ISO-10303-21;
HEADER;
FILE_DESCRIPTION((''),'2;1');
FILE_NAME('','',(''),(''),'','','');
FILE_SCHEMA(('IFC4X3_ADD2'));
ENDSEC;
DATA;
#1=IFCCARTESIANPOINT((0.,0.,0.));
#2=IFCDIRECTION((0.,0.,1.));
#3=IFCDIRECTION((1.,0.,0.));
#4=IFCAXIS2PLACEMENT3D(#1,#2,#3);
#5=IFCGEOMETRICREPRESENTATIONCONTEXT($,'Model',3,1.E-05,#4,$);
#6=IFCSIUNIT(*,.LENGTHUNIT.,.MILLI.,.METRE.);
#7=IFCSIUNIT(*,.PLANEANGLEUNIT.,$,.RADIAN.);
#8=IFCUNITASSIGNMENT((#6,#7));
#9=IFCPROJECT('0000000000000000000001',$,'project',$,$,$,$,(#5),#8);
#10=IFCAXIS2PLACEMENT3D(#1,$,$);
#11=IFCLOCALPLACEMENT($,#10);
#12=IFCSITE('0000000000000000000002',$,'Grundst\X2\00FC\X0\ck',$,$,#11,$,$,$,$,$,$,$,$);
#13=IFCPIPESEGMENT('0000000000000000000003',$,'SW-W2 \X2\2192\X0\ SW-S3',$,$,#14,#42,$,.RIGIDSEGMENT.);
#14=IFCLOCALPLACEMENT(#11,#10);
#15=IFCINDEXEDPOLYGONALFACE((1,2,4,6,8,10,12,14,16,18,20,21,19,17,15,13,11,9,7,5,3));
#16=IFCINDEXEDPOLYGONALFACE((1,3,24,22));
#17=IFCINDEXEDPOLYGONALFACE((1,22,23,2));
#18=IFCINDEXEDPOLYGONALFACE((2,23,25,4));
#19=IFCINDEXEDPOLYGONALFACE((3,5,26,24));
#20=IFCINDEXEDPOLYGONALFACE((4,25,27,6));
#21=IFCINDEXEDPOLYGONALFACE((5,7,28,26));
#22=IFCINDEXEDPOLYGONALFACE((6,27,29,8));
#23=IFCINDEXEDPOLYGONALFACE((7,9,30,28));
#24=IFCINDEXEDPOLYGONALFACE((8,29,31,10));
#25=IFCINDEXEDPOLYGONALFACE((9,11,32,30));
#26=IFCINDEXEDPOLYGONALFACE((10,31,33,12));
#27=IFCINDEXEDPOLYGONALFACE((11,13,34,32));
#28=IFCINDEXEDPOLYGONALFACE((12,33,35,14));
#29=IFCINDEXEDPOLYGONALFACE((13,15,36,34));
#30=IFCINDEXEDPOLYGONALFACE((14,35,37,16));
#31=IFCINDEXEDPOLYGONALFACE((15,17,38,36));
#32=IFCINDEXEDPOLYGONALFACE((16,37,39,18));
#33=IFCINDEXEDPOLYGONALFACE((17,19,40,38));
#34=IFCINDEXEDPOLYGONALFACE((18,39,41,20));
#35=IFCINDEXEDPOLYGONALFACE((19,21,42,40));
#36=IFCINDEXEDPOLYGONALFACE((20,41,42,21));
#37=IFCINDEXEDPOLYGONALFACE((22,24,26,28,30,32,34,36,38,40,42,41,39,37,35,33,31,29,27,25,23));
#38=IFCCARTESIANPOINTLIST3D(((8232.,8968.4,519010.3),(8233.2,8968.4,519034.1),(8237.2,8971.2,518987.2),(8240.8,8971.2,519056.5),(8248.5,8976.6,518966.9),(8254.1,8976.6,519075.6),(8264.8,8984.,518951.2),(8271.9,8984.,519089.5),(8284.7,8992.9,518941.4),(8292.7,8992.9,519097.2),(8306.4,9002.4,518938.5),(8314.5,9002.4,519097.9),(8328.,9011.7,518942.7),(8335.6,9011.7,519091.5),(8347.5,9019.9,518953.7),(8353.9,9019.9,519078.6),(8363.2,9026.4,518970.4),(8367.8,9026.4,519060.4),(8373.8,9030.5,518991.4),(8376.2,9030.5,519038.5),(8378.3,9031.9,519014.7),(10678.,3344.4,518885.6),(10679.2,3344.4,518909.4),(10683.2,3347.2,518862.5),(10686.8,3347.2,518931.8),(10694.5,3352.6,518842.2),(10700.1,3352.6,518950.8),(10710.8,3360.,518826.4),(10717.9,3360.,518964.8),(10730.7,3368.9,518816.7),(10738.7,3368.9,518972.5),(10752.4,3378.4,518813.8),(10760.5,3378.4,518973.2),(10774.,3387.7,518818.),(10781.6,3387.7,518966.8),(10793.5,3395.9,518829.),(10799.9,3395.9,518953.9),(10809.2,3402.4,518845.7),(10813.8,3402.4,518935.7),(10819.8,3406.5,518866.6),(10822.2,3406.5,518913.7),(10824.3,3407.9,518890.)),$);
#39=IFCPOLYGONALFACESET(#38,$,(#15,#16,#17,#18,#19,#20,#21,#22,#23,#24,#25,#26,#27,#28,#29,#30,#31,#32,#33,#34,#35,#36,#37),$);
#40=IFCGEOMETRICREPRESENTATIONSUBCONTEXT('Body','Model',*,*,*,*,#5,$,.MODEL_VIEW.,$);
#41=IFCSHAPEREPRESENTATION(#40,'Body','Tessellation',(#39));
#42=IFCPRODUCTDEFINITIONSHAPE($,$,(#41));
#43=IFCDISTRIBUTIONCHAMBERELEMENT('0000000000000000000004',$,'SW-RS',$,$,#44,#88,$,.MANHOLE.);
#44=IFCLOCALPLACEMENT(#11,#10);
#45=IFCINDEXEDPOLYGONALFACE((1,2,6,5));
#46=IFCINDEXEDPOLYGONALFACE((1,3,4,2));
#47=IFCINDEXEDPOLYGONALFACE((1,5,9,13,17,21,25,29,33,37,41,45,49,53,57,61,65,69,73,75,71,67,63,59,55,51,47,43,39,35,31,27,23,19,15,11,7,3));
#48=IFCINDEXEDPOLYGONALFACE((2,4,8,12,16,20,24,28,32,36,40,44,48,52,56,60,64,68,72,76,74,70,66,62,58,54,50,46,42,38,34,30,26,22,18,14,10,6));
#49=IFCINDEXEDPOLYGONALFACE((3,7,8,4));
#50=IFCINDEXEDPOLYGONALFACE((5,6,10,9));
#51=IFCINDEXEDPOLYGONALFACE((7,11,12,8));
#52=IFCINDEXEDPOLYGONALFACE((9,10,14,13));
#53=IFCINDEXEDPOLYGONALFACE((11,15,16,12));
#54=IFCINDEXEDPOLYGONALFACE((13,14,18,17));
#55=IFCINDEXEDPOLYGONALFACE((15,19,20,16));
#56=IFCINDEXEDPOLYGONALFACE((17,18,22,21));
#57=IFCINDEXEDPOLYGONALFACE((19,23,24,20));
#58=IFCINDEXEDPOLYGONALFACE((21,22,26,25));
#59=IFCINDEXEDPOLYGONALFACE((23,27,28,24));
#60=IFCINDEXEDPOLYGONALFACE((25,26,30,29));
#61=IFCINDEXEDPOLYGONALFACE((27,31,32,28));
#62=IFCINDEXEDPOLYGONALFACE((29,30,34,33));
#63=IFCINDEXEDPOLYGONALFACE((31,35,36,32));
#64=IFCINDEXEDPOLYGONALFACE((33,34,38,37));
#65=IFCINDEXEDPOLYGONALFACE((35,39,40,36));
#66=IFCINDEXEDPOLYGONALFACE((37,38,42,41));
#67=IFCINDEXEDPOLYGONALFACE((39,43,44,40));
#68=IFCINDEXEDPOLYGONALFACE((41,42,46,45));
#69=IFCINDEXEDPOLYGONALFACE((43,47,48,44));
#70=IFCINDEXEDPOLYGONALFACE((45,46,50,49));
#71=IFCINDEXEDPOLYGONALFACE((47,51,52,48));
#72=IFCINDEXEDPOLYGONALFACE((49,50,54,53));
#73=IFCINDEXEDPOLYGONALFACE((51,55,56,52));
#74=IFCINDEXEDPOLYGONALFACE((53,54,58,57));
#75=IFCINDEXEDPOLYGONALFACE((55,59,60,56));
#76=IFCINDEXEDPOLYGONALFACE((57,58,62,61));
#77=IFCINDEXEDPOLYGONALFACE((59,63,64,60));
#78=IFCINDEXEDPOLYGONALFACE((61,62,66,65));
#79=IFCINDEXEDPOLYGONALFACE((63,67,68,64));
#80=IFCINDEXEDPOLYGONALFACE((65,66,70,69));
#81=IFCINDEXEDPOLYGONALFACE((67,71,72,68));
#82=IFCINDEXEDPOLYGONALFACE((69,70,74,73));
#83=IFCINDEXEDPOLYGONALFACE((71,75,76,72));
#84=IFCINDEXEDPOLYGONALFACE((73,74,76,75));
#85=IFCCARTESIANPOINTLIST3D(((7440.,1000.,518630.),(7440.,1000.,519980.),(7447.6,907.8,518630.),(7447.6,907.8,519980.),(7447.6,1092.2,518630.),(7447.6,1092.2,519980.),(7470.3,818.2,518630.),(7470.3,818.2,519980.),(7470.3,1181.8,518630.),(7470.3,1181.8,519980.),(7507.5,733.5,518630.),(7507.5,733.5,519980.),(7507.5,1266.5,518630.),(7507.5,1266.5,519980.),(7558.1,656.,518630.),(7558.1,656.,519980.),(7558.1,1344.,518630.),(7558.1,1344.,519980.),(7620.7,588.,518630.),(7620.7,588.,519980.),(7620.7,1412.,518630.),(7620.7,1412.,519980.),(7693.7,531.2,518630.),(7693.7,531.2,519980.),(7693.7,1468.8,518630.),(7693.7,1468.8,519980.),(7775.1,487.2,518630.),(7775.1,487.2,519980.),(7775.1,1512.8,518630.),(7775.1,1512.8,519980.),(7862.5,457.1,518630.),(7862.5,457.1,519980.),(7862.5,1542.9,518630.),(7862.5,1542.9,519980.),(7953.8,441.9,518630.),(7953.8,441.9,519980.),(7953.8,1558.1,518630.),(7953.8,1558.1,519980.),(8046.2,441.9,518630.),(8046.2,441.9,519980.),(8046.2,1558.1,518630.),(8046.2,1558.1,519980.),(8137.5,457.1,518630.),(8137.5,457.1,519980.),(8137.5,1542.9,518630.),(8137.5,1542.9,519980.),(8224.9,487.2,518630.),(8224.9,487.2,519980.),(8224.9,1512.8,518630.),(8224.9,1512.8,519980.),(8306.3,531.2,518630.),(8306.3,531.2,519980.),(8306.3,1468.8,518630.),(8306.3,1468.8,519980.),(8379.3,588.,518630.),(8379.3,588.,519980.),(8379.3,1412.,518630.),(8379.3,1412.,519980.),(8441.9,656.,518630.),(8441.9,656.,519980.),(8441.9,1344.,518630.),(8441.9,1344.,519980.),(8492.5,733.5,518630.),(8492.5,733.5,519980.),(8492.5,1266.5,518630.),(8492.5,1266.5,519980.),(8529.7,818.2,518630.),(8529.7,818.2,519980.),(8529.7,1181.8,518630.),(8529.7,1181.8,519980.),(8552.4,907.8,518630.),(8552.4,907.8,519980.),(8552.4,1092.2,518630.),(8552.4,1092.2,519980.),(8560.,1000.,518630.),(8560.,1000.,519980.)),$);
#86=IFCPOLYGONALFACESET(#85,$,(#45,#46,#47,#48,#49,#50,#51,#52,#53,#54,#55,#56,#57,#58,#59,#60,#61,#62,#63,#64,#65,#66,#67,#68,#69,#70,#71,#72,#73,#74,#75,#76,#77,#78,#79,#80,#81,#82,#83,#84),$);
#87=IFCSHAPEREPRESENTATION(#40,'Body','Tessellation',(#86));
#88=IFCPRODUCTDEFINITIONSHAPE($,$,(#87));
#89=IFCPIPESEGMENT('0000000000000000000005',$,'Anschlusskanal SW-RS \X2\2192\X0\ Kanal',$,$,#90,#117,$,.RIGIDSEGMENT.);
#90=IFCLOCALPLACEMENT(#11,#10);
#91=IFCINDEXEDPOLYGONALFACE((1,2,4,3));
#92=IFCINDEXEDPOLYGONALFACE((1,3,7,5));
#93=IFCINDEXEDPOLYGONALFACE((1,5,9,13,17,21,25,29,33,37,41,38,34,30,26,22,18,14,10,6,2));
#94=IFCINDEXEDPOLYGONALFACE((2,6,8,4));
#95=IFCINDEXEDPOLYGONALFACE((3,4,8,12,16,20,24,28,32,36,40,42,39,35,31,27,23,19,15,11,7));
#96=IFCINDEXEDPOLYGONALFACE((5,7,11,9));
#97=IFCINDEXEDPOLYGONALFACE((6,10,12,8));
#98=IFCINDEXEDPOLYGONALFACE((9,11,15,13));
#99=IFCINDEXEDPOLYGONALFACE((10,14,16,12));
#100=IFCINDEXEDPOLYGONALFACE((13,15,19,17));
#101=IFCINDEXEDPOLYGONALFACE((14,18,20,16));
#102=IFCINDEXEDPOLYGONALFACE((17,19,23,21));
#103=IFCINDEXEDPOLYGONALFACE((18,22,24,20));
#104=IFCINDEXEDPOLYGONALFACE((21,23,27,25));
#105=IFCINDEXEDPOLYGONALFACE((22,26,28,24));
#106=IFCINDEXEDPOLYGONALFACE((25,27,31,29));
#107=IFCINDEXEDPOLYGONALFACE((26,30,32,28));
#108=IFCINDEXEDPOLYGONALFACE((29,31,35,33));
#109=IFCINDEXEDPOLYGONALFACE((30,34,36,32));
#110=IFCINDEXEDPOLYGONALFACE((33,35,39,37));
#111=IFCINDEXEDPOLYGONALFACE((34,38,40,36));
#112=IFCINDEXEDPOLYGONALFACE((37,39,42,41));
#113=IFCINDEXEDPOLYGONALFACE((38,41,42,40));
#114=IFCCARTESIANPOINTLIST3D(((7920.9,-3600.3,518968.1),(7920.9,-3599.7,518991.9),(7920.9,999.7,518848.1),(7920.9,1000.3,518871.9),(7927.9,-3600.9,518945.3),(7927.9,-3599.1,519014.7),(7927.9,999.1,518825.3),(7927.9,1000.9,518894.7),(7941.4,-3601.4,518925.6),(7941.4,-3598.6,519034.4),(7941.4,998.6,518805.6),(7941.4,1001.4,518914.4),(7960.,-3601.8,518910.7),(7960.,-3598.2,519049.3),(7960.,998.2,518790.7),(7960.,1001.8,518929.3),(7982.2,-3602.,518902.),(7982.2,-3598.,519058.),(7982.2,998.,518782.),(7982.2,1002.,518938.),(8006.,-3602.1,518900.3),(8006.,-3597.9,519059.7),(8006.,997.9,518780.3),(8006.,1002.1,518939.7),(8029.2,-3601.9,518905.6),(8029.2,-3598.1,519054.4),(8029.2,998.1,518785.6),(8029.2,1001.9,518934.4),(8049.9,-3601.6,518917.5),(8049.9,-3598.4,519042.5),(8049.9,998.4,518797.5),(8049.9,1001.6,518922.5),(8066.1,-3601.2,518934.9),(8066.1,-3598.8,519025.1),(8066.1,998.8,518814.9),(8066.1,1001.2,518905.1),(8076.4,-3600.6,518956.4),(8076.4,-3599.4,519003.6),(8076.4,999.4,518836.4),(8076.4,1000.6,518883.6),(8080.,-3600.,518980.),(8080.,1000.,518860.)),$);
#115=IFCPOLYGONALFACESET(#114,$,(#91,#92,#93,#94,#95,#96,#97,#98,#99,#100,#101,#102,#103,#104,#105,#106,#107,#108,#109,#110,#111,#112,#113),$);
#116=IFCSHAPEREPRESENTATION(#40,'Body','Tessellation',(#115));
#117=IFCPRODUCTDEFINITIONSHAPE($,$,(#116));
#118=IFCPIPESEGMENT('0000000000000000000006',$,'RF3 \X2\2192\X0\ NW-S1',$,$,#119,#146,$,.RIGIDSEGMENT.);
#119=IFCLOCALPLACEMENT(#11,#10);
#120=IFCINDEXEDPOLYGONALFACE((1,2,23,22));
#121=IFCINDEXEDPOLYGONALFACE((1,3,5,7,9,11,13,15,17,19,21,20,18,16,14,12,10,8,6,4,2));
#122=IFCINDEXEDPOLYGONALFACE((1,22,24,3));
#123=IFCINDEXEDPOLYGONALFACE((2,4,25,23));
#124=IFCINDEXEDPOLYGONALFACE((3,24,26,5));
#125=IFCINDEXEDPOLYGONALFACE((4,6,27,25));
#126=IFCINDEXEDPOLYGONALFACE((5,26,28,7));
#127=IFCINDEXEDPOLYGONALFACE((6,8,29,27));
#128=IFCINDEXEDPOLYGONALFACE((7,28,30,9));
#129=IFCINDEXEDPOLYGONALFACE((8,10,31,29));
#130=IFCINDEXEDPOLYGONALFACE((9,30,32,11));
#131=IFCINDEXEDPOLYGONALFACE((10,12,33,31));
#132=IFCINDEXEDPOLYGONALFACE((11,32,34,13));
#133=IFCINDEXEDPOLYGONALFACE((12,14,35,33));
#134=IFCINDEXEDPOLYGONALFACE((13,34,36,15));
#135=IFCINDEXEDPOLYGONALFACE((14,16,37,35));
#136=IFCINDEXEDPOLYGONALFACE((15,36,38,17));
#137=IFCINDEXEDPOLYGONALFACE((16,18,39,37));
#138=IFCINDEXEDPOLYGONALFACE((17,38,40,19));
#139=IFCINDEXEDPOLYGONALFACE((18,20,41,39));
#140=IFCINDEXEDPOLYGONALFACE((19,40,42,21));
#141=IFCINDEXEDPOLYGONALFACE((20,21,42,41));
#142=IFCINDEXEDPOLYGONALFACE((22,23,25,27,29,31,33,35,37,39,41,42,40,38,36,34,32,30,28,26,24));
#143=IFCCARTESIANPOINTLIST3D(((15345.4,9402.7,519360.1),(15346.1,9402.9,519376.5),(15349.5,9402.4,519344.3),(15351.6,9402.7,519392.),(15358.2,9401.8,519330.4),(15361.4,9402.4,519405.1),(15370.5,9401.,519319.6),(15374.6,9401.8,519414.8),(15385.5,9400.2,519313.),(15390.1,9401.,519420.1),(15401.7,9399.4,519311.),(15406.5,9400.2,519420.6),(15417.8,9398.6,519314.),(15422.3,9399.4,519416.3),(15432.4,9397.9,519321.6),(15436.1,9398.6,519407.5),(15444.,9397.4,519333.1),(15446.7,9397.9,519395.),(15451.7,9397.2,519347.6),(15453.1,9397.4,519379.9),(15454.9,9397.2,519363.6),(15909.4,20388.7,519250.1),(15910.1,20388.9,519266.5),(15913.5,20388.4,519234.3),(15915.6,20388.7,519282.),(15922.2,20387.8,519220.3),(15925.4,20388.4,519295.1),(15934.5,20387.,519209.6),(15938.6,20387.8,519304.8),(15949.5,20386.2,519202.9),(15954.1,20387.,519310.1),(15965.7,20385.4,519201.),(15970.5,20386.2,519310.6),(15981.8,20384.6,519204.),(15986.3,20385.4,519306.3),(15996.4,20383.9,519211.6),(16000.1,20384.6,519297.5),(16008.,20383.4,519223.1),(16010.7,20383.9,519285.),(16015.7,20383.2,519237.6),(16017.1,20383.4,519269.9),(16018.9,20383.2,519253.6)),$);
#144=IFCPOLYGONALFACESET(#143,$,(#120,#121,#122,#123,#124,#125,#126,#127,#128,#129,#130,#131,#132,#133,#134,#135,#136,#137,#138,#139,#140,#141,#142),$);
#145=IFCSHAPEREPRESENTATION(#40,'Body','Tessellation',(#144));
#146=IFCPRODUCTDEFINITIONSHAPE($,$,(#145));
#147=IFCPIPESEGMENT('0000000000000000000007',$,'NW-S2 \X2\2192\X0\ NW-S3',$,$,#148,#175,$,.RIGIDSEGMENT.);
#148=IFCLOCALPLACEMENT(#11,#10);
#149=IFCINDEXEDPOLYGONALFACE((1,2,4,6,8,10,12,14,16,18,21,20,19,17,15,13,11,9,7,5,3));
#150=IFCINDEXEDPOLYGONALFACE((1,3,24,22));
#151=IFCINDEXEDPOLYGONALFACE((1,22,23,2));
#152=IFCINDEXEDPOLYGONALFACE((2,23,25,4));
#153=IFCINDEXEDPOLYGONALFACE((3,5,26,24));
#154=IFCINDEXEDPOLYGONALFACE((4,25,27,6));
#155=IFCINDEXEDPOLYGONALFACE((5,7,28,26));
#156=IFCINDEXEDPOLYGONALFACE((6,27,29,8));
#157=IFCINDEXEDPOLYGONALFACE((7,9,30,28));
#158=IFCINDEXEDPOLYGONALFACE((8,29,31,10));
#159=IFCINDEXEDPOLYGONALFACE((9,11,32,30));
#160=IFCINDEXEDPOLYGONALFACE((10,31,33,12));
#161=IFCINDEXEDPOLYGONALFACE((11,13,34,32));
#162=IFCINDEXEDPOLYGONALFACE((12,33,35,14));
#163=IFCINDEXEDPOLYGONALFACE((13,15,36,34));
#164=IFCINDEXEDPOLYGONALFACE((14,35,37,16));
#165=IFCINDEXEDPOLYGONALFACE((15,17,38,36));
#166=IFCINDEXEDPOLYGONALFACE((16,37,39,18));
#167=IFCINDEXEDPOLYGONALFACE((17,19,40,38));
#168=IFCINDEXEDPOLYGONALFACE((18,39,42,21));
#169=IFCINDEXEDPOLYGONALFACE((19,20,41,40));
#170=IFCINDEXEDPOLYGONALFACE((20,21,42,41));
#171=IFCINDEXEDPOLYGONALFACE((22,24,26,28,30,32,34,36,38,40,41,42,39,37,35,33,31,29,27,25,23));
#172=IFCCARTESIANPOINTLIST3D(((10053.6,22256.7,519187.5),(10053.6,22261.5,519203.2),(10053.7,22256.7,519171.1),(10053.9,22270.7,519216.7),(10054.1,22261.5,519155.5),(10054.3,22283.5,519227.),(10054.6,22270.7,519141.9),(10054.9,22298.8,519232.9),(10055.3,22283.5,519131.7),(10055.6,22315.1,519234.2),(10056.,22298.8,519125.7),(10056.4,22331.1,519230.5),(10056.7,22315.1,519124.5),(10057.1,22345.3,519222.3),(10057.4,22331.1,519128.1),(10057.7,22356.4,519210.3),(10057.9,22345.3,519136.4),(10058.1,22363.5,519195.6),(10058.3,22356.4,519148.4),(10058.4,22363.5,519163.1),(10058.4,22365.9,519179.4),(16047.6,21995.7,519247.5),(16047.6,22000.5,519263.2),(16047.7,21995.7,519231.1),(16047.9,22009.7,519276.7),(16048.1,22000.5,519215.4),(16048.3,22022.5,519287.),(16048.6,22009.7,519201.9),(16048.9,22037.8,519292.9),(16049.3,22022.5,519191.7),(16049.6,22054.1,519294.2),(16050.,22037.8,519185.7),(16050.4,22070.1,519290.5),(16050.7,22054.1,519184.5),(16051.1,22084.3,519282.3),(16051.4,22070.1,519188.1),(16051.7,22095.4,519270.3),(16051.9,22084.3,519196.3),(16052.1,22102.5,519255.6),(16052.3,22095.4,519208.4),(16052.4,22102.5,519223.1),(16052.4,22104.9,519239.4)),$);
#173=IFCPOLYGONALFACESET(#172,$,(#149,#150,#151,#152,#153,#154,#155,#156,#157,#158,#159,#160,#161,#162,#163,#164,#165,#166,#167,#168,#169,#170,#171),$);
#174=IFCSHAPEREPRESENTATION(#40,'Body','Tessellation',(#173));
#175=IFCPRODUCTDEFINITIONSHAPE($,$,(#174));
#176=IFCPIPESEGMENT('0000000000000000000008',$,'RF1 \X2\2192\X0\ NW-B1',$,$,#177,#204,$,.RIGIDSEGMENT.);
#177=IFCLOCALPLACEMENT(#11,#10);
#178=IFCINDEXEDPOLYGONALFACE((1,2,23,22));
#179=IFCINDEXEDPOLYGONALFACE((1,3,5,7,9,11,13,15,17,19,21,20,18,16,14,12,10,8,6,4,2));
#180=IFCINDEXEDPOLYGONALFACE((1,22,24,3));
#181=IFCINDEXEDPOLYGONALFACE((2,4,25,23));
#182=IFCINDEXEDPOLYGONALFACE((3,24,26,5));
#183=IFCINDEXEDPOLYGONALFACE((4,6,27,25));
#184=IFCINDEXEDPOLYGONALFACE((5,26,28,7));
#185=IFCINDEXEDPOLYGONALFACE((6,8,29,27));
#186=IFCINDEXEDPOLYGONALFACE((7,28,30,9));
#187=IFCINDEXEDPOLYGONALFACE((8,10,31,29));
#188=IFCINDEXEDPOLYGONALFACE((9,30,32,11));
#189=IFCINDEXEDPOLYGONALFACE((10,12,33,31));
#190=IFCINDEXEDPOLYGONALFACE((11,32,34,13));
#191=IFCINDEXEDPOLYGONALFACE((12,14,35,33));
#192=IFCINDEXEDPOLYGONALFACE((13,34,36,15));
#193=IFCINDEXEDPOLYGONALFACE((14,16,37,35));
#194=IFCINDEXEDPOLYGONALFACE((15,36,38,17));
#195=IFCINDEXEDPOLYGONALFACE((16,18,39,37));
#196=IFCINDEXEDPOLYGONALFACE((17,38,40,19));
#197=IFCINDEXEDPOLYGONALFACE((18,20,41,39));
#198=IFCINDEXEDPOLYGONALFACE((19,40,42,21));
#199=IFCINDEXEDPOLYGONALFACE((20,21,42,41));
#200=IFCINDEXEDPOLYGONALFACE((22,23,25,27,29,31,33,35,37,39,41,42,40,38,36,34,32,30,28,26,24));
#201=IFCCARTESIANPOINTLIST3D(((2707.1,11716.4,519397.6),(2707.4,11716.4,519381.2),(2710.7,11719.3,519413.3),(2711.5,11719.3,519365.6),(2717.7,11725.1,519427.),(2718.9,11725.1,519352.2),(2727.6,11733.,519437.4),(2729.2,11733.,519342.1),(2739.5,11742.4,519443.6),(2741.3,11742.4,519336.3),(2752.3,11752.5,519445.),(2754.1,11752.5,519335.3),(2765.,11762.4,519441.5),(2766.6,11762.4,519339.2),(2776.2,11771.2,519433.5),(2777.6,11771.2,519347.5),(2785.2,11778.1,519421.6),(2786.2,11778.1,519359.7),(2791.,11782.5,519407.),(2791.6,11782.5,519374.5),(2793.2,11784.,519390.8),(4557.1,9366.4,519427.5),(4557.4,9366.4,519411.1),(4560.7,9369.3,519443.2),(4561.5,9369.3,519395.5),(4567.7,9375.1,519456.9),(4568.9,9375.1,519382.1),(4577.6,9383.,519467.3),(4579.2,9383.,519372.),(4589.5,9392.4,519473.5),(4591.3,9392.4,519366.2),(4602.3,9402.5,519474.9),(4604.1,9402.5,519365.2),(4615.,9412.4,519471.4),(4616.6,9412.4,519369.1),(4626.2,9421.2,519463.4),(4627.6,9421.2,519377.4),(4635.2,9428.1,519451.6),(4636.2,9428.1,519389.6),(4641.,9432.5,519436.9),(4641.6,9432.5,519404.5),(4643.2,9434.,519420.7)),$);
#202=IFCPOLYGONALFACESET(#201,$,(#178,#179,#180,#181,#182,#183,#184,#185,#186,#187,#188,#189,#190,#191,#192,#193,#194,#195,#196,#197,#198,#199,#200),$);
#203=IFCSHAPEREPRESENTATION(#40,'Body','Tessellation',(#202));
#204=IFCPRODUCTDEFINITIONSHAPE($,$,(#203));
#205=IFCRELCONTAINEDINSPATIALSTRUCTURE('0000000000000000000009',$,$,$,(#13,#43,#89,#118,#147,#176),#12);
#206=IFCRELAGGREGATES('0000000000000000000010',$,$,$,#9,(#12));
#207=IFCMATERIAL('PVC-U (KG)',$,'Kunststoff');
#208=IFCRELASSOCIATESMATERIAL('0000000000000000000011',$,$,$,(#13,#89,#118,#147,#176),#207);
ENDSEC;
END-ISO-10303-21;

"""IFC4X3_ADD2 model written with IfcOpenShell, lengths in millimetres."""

from ifc_helpers import new_model, si_unit, frame, origin, origin_with_axes, place, context, subcontext, project, spatial, circle, extrude, material, element, save


model = new_model("IFC4X3_ADD2")

# Units and contexts
model_context = context("Model", 3, precision=1e-05, world=origin_with_axes())
body_context = subcontext(model_context, "Body", "Model", "MODEL_VIEW")
ifc_project = project(units=[si_unit("LENGTHUNIT", "METRE", prefix="MILLI"), si_unit("PLANEANGLEUNIT", "RADIAN")], contexts=[model_context])

# Site
site_placement = place(None, origin())
site = spatial("IfcSite", under=ifc_project, at=site_placement, Name="Grundstück")

# Pipe segment
ifc_material = material(Name="PVC-U (KG)", Category="Kunststoff")
pipe_segment_1_placement = place(site_placement, frame((8305.0, 9000.0, 518938.5)))
element("IfcPipeSegment", 1, at=pipe_segment_1_placement, inside=site, material=ifc_material, Name="SW-W2 → SW-S3", PredefinedType="RIGIDSEGMENT", context=body_context, shape_type="SweptSolid", body=[
    extrude(circle(Radius=80.0), frame((0.0, 0.0, 80.0), z_axis=(0.398751, -0.916834, -0.02033), x_axis=(0.0, 1.0, 0.0)), (0.0, 0.0, 1.0), 6134.2),
])

# Distribution chamber element
distribution_chamber_element_1_placement = place(site_placement, frame((8000.0, 1000.0, 518780.0)))
element("IfcDistributionChamberElement", 2, at=distribution_chamber_element_1_placement, inside=site, Name="SW-RS", PredefinedType="MANHOLE", context=body_context, shape_type="SweptSolid", body=[
    extrude(circle(Radius=560.0), frame((0.0, 0.0, -150.0)), (0.0, 0.0, 1.0), 1350.0),
])

# Pipe segments
pipe_segment_2_placement = place(site_placement, frame((8000.0, 1000.0, 518780.0)))
element("IfcPipeSegment", 3, at=pipe_segment_2_placement, inside=site, material=ifc_material, Name="Anschlusskanal SW-RS → Kanal", PredefinedType="RIGIDSEGMENT", context=body_context, shape_type="SweptSolid", body=[
    extrude(circle(Radius=80.0), frame((0.0, 0.0, 80.0), z_axis=(0.0, -0.99966, 0.026078), x_axis=(1.0, 0.0, 0.0)), (0.0, 0.0, 1.0), 4601.6),
])
pipe_segment_3_placement = place(site_placement, frame((15400.0, 9400.0, 519311.0)))
element("IfcPipeSegment", 4, at=pipe_segment_3_placement, inside=site, material=ifc_material, Name="RF3 → NW-S1", PredefinedType="RIGIDSEGMENT", context=body_context, shape_type="SweptSolid", body=[
    extrude(circle(Radius=55.0), frame((0.0, 0.0, 55.0), z_axis=(0.051268, 0.998635, -0.01), x_axis=(0.0, 1.0, 0.0)), (0.0, 0.0, 1.0), 11001.0),
])
pipe_segment_4_placement = place(site_placement, frame((16050.0, 22050.0, 519184.3)))
element("IfcPipeSegment", 5, at=pipe_segment_4_placement, inside=site, material=ifc_material, Name="NW-S2 → NW-S3", PredefinedType="RIGIDSEGMENT", context=body_context, shape_type="SweptSolid", body=[
    extrude(circle(Radius=55.0), frame((0.0, 0.0, 55.0), z_axis=(-0.999003, 0.0435, -0.01), x_axis=(0.0, 1.0, 0.0)), (0.0, 0.0, 1.0), 6000.0),
])
pipe_segment_5_placement = place(site_placement, frame((4600.0, 9400.0, 519365.0)))
element("IfcPipeSegment", 6, at=pipe_segment_5_placement, inside=site, material=ifc_material, Name="RF1 → NW-B1", PredefinedType="RIGIDSEGMENT", context=body_context, shape_type="SweptSolid", body=[
    extrude(circle(Radius=55.0), frame((0.0, 0.0, 55.0), z_axis=(-0.618529, 0.785699, -0.01), x_axis=(0.0, 1.0, 0.0)), (0.0, 0.0, 1.0), 2991.0),
])

save(model, "model.ifc")
